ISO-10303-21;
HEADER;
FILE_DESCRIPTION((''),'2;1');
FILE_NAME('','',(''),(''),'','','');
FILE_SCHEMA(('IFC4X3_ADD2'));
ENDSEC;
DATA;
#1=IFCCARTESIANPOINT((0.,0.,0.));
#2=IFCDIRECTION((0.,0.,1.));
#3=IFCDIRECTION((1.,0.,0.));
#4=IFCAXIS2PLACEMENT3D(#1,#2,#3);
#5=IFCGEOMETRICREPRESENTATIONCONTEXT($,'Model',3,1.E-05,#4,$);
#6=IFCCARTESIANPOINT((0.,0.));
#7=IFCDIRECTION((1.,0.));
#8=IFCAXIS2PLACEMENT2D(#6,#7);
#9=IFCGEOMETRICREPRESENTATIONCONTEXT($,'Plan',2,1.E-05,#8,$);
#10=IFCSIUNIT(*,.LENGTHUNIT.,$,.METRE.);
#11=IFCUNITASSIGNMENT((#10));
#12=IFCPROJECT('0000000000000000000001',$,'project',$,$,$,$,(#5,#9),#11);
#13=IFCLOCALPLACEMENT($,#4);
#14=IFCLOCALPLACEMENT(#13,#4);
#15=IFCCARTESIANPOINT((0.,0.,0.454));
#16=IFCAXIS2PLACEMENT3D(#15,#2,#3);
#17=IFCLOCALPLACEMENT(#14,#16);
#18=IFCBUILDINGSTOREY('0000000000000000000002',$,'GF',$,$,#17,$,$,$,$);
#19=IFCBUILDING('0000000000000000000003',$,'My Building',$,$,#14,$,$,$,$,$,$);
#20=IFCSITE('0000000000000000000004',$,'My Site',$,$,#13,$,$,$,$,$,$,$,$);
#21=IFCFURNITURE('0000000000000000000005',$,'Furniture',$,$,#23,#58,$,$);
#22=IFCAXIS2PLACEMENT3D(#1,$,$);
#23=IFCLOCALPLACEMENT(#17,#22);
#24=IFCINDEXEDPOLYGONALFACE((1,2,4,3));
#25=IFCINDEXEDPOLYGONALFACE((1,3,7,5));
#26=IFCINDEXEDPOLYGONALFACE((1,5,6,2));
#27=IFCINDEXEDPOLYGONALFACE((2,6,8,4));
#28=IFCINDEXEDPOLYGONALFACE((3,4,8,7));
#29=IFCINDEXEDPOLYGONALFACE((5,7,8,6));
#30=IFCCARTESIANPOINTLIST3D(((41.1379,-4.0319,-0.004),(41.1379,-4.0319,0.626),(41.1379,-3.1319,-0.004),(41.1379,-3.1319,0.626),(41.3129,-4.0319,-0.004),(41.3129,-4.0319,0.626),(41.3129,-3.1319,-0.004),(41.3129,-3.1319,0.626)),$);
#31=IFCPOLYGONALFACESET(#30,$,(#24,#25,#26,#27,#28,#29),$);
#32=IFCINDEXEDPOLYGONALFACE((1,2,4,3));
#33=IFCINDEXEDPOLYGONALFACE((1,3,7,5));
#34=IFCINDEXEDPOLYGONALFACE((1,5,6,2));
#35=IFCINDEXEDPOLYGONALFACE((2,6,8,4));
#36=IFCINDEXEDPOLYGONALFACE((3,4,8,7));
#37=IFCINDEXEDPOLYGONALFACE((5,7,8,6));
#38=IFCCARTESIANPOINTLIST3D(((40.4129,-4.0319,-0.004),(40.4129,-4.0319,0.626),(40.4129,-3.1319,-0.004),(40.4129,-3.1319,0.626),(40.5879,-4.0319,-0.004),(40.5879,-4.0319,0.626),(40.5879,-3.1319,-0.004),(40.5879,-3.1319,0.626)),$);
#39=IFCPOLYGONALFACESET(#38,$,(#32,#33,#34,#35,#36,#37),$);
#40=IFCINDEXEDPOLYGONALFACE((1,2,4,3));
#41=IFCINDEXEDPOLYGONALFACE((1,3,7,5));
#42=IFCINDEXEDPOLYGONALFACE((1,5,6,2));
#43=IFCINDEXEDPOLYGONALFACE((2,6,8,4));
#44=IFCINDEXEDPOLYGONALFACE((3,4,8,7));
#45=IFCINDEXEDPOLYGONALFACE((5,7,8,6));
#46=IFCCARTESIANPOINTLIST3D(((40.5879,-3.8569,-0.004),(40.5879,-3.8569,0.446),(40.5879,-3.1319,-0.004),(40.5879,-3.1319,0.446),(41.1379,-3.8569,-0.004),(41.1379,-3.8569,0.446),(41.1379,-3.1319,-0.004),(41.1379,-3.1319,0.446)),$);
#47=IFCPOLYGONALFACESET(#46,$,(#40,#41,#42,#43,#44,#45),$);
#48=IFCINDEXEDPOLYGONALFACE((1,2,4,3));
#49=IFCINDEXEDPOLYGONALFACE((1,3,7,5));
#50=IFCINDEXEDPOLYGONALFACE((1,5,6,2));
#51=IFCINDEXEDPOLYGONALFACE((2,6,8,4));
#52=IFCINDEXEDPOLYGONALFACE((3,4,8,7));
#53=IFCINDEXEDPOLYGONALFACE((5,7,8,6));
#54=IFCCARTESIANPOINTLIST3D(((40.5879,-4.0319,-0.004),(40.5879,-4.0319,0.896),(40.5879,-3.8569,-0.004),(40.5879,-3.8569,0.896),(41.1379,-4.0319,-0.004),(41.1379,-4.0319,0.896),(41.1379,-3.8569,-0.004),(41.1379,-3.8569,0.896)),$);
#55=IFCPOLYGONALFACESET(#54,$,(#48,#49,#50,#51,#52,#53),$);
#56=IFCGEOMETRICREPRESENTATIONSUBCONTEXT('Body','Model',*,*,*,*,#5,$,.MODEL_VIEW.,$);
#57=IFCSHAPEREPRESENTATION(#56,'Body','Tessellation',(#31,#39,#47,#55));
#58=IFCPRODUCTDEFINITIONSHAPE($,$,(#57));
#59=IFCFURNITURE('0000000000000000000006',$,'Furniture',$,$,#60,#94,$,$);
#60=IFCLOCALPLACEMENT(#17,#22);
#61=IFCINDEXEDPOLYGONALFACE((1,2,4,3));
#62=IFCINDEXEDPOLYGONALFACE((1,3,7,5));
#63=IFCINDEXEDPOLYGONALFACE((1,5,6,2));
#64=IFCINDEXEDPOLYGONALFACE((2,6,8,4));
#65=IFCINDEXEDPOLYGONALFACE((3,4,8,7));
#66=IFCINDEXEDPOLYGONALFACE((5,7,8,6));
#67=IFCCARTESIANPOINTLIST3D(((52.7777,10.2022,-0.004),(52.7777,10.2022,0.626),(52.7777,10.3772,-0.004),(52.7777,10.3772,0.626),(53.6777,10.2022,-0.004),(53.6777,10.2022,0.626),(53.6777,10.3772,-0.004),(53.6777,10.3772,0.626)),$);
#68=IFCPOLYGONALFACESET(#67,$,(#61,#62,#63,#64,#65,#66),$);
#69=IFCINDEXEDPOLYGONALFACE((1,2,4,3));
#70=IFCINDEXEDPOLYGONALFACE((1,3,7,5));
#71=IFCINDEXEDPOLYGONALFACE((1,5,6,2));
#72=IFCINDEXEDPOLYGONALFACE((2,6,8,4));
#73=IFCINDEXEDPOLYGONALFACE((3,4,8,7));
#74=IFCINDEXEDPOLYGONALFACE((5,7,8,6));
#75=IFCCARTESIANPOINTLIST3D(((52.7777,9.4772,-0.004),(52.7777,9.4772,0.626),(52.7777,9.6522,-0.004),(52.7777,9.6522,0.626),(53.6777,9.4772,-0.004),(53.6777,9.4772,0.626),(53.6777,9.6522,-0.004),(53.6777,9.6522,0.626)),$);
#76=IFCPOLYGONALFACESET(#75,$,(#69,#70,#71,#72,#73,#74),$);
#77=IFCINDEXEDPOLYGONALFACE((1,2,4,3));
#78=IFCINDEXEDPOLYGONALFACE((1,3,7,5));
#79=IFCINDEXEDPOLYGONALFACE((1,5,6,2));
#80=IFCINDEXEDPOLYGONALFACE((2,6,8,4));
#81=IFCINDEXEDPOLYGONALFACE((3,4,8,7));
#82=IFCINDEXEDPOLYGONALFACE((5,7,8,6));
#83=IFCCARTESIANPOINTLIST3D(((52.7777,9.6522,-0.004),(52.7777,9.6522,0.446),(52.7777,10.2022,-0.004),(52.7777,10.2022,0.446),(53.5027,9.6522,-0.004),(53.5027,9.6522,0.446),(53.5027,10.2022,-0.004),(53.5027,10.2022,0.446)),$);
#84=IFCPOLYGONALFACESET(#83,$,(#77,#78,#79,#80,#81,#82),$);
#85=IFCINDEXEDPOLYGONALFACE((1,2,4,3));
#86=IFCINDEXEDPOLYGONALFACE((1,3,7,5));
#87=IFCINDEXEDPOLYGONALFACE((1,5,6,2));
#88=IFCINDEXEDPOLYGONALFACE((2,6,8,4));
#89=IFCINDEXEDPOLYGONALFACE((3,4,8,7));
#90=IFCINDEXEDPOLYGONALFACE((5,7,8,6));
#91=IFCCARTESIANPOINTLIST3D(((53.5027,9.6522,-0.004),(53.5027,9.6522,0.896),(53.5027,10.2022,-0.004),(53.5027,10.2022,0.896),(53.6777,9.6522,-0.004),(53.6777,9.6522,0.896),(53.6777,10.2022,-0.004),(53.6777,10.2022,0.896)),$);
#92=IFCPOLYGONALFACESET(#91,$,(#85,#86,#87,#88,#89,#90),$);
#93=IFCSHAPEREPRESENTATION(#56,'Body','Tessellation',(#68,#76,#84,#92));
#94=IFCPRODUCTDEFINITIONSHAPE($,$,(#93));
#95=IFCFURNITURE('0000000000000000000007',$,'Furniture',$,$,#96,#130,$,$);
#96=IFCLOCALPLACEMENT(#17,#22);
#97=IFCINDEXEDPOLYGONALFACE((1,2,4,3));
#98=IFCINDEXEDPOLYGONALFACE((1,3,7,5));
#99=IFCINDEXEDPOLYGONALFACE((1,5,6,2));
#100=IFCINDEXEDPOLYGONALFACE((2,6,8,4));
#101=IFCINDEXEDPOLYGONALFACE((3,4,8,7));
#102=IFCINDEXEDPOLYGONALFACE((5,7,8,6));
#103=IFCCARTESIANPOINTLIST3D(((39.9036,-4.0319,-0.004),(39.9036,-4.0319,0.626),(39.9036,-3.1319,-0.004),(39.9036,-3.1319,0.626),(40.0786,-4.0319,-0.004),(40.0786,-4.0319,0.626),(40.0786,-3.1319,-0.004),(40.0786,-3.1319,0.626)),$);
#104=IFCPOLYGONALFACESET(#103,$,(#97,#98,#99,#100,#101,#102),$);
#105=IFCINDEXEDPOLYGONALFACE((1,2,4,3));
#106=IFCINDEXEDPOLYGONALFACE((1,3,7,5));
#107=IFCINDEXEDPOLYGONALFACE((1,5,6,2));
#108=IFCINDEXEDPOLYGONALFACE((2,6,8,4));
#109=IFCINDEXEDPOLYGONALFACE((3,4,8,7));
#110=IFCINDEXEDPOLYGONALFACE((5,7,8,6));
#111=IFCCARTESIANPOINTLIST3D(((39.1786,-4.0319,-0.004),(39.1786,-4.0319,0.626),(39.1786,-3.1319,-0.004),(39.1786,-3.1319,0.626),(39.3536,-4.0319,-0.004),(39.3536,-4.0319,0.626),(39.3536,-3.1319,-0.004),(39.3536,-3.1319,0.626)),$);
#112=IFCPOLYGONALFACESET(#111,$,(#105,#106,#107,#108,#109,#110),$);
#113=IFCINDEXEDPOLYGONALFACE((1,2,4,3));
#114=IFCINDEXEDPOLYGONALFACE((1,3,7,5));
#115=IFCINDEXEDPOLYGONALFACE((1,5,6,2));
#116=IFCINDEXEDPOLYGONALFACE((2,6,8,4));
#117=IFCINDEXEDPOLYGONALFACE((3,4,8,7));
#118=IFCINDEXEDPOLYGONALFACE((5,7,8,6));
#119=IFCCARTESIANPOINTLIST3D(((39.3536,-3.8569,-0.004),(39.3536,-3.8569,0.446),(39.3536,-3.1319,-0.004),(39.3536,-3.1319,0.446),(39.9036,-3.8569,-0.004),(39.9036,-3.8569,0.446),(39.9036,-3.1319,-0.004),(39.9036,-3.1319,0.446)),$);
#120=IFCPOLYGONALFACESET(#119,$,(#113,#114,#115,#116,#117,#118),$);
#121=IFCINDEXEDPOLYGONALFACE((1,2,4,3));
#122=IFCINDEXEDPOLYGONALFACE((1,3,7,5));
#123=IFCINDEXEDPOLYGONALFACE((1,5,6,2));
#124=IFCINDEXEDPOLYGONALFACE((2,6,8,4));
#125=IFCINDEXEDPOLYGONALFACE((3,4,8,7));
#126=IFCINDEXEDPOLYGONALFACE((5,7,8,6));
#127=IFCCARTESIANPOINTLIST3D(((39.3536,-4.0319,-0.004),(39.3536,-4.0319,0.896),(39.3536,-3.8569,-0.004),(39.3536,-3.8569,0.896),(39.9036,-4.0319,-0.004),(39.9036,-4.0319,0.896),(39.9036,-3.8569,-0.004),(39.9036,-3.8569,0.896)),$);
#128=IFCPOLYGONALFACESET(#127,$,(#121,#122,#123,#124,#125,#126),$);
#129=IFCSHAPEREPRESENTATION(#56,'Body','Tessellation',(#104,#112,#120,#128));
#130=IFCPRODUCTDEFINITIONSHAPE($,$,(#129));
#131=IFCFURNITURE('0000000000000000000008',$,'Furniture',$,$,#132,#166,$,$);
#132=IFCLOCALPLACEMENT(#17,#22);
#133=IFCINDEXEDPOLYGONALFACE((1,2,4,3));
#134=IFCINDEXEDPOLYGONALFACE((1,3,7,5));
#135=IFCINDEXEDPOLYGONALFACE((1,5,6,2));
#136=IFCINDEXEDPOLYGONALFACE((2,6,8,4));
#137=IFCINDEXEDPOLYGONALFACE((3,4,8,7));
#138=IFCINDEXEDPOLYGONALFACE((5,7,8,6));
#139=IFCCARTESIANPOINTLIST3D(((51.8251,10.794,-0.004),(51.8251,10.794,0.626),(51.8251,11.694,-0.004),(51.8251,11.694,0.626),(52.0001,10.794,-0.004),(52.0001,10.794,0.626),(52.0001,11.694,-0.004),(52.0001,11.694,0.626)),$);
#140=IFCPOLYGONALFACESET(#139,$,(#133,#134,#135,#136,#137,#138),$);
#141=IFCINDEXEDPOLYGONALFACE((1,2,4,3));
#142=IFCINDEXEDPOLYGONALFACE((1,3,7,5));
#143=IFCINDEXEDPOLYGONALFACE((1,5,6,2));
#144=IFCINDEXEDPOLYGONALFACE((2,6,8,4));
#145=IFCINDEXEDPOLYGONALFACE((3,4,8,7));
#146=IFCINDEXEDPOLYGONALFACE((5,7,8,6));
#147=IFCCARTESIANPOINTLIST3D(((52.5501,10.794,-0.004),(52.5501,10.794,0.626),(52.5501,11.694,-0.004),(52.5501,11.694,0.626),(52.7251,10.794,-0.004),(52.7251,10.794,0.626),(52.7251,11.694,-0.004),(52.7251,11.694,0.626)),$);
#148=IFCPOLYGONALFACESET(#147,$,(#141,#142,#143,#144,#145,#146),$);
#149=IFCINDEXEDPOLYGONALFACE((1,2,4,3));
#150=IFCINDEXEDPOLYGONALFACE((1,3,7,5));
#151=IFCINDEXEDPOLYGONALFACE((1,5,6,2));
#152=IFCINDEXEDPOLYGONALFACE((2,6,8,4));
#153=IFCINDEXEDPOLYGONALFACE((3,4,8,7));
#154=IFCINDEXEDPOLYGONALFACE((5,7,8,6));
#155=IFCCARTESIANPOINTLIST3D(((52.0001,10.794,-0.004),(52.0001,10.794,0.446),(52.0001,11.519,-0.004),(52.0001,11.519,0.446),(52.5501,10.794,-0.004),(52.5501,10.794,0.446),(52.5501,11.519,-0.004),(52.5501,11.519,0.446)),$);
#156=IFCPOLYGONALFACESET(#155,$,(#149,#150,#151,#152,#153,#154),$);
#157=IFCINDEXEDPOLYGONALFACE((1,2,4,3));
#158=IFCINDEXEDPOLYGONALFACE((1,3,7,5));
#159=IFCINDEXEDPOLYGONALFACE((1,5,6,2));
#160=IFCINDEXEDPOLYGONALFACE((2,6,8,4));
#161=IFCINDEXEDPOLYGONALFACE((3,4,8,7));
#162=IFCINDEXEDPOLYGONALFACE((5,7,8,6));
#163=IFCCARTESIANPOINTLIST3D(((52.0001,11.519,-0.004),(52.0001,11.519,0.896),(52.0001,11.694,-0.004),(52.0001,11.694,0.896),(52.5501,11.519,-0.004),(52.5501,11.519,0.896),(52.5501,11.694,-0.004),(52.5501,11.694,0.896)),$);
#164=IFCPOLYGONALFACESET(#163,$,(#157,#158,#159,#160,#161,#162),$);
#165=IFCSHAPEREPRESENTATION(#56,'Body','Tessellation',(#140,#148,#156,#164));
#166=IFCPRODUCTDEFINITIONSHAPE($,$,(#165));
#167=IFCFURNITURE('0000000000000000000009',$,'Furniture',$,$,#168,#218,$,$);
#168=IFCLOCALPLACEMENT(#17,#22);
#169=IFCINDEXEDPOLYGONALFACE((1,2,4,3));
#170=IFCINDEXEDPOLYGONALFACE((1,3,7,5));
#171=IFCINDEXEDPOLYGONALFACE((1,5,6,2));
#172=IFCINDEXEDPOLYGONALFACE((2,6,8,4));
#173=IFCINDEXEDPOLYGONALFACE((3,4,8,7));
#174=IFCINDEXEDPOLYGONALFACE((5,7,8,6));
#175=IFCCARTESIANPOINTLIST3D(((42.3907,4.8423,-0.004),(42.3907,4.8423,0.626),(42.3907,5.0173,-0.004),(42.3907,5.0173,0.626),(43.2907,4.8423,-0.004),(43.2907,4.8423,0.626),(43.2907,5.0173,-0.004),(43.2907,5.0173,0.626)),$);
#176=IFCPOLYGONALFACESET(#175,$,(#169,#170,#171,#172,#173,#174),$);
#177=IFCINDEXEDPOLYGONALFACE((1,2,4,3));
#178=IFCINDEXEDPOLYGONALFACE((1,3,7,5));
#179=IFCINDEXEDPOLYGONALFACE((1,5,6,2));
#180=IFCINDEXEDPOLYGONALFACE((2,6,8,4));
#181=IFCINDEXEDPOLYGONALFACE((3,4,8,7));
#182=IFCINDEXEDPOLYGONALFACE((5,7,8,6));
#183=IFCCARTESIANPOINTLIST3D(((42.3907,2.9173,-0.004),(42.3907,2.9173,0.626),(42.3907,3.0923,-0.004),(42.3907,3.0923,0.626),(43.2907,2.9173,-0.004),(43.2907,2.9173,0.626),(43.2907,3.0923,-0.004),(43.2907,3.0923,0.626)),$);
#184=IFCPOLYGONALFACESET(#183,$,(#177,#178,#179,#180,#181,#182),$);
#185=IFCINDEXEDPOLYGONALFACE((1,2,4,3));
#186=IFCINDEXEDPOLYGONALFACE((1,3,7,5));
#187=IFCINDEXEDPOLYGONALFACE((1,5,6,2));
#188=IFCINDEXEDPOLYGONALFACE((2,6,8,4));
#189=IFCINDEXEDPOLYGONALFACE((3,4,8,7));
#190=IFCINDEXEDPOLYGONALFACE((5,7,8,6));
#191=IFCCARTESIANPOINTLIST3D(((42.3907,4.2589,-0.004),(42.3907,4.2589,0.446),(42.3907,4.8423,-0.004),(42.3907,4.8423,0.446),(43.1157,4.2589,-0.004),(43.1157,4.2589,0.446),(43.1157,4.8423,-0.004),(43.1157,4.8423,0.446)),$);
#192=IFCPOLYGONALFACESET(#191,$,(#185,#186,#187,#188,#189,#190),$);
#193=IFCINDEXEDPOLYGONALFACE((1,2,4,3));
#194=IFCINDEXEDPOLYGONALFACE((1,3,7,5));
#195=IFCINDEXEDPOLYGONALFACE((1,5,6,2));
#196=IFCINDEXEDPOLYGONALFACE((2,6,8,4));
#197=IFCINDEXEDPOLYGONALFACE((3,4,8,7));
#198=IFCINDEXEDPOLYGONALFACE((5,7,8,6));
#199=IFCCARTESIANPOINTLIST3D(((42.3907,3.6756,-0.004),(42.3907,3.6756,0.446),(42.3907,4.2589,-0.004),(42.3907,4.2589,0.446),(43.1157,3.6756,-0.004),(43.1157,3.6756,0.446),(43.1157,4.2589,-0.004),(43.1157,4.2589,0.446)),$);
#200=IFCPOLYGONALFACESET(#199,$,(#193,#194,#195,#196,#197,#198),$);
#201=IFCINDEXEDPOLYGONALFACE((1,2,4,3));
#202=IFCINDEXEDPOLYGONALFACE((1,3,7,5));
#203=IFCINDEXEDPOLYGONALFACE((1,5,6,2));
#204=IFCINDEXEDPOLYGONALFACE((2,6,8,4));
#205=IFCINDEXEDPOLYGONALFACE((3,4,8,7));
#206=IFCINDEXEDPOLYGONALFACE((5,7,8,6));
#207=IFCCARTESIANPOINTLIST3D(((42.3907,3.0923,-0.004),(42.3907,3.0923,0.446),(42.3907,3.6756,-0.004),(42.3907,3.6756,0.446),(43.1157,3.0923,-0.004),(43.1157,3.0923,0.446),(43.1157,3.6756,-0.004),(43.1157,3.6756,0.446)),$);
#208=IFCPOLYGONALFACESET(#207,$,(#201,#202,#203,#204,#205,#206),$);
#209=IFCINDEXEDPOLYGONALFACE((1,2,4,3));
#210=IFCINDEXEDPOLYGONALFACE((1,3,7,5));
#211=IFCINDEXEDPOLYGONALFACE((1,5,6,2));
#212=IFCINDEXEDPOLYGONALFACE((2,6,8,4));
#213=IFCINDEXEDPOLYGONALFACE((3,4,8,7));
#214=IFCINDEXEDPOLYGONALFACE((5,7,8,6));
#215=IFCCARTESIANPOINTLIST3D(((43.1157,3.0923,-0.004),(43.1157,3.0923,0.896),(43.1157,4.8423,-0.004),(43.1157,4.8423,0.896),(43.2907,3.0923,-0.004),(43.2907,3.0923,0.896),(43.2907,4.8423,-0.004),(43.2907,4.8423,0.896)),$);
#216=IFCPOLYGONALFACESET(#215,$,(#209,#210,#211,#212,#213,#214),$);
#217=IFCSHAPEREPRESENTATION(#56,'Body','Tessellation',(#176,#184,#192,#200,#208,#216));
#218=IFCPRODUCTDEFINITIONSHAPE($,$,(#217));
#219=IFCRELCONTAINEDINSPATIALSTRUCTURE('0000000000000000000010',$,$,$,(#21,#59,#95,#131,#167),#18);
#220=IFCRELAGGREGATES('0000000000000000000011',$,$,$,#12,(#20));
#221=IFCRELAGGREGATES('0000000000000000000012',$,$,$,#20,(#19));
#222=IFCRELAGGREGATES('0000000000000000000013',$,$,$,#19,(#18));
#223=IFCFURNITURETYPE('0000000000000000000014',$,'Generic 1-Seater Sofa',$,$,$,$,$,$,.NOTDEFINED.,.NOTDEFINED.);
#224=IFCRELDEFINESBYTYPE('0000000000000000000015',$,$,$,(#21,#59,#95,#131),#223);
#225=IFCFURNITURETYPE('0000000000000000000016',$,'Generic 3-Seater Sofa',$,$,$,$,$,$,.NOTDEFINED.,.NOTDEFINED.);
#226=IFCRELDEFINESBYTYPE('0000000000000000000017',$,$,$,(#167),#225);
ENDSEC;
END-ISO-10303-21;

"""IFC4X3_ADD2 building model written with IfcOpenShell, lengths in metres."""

from ifc_helpers import new_model, entity, si_unit, frame, origin_with_axes, origin_2d_with_axis, place, context, subcontext, project, spatial, line, indexed_curve, outline, extrude, shape, source, transform, mapped, type_object, type_shapes, element, save


model = new_model("IFC4X3_ADD2")

# Units and contexts
model_context = context("Model", 3, precision=1e-05, world=origin_with_axes())
plan_context = context("Plan", 2, precision=1e-05, world=origin_2d_with_axis())
body_context_1 = subcontext(model_context, "Body", "Model", "MODEL_VIEW")
body_context_2 = subcontext(plan_context, "Body", "Plan", "PLAN_VIEW")
ifc_project = project(units=[si_unit("LENGTHUNIT", "METRE")], contexts=[model_context, plan_context])

# Site, building, storey
site_placement = place(None, origin_with_axes())
site = spatial("IfcSite", under=ifc_project, at=site_placement, Name="My Site")
building_placement = place(site_placement, origin_with_axes())
building = spatial("IfcBuilding", under=site, at=building_placement, Name="My Building")
storey_placement = place(building_placement, frame((0.0, 0.0, 0.454), z_axis=(0.0, 0.0, 1.0), x_axis=(1.0, 0.0, 0.0)))
storey = spatial("IfcBuildingStorey", under=building, at=storey_placement, Name="GF")

# Furniture
furniture_type_1 = type_object("IfcFurnitureType", Name="Generic 1-Seater Sofa", AssemblyPlace="NOTDEFINED", PredefinedType="NOTDEFINED")
shared_shape_1 = source(origin_with_axes(), body_context_1, "Body", "SweptSolid", [
    extrude(outline(indexed_curve([(0.0, 0.0), (0.175, 0.0), (0.175, 0.9), (0.0, 0.9)], segments=[line(4, 1), line(1, 2), line(2, 3), line(3, 4)], self_intersect=False)), frame((-0.45, -0.9, 0.0), z_axis=(0.0, 0.0, 1.0), x_axis=(1.0, 0.0, 0.0)), (0.0, 0.0, 1.0), 0.63),
    extrude(outline(indexed_curve([(0.0, 0.0), (0.175, 0.0), (0.175, 0.9), (0.0, 0.9)], segments=[line(1, 2, 3, 4, 1)])), frame((0.275, -0.9, 0.0), z_axis=(0.0, 0.0, 1.0), x_axis=(1.0, 0.0, 0.0)), (0.0, 0.0, 1.0), 0.63),
    extrude(outline(indexed_curve([(0.175, 0.0), (0.725, 0.0), (0.725, 0.725), (0.175, 0.725)], segments=[line(1, 2, 3, 4, 1)])), frame((-0.45, -0.9, 0.0), z_axis=(0.0, 0.0, 1.0), x_axis=(1.0, 0.0, 0.0)), (0.0, 0.0, 1.0), 0.45),
    extrude(outline(indexed_curve([(0.175, 0.725), (0.725, 0.725), (0.725, 0.9), (0.175, 0.9)], segments=[line(1, 2, 3, 4, 1)])), frame((-0.45, -0.9, 0.0), z_axis=(0.0, 0.0, 1.0), x_axis=(1.0, 0.0, 0.0)), (0.0, 0.0, 1.0), 0.9),
])
shared_shape_2 = source(origin_with_axes(), body_context_2, "Body", "Annotation2D", [
    entity("IfcGeometricCurveSet", [entity("IfcIndexedPolyCurve", entity("IfcCartesianPointList2D", [[0.275, -0.175], [0.275, -0.9], [0.45, -0.9], [0.45, 0.0], [0.275, 0.0], [0.275, -0.9], [-0.275, -0.9], [-0.275, 0.0], [-0.275, -0.175], [0.275, -0.175], [0.275, 0.0], [-0.275, 0.0], [-0.45, 0.0], [-0.45, -0.9], [-0.275, -0.9], [-0.275, -0.175]]))]),
])
type_shapes(furniture_type_1, [shared_shape_1, shared_shape_2])
for number, where, z_axis, x_axis, name in (
    (1, (40.8629, -4.0319, -0.004), (0.0, 0.0, 1.0), (-1.0, 0.0, 0.0), "Furniture"),
    (2, (53.6777, 9.9272, -0.004), (0.0, 0.0, 1.0), (0.0, -1.0, 0.0), "Furniture"),
    (3, (39.6286, -4.0319, -0.004), (0.0, 0.0, 1.0), (-1.0, 0.0, 0.0), "Furniture"),
    (4, (52.2751, 11.694, -0.004), (0.0, 0.0, 1.0), (1.0, 0.0, 0.0), "Furniture"),
):
    element("IfcFurniture", number, at=place(storey_placement, frame(where, z_axis=z_axis, x_axis=x_axis)), inside=storey, type_object=furniture_type_1, Name=name, shapes=[
        shape(body_context_1, "Body", "MappedRepresentation", [mapped(shared_shape_1, transform((0.0, 0.0, 0.0), x_axis=(1.0, 0.0, 0.0), y_axis=(0.0, 1.0, 0.0), z_axis=(0.0, 0.0, 1.0), scale=1.0))]),
        shape(body_context_2, "Body", "MappedRepresentation", [mapped(shared_shape_2, transform((0.0, 0.0, 0.0), x_axis=(1.0, 0.0, 0.0), y_axis=(0.0, 1.0, 0.0), z_axis=(0.0, 0.0, 1.0), scale=1.0))]),
    ])
furniture_type_2 = type_object("IfcFurnitureType", Name="Generic 3-Seater Sofa", AssemblyPlace="NOTDEFINED", PredefinedType="NOTDEFINED")
shared_shape_3 = source(origin_with_axes(), body_context_1, "Body", "SweptSolid", [
    extrude(outline(indexed_curve([(0.0, 0.0), (0.175, 0.0), (0.175, 0.9), (0.0, 0.9)], segments=[line(4, 1), line(1, 2), line(2, 3), line(3, 4)], self_intersect=False)), frame((-1.05, -0.9, 0.0), z_axis=(0.0, 0.0, 1.0), x_axis=(1.0, 0.0, 0.0)), (0.0, 0.0, 1.0), 0.63),
    extrude(outline(indexed_curve([(0.0, 0.0), (0.175, 0.0), (0.175, 0.9), (0.0, 0.9)], segments=[line(1, 2, 3, 4, 1)])), frame((0.875, -0.9, 0.0), z_axis=(0.0, 0.0, 1.0), x_axis=(1.0, 0.0, 0.0)), (0.0, 0.0, 1.0), 0.63),
    extrude(outline(indexed_curve([(0.175, 0.0), (0.7583, 0.0), (0.7583, 0.725), (0.175, 0.725)], segments=[line(1, 2, 3, 4, 1)])), frame((-1.05, -0.9, 0.0), z_axis=(0.0, 0.0, 1.0), x_axis=(1.0, 0.0, 0.0)), (0.0, 0.0, 1.0), 0.45),
    extrude(outline(indexed_curve([(0.7583, 0.0), (1.3417, 0.0), (1.3417, 0.725), (0.7583, 0.725)], segments=[line(1, 2, 3, 4, 1)])), frame((-1.05, -0.9, 0.0), z_axis=(0.0, 0.0, 1.0), x_axis=(1.0, 0.0, 0.0)), (0.0, 0.0, 1.0), 0.45),
    extrude(outline(indexed_curve([(1.3417, 0.0), (1.925, 0.0), (1.925, 0.725), (1.3417, 0.725)], segments=[line(1, 2, 3, 4, 1)])), frame((-1.05, -0.9, 0.0), z_axis=(0.0, 0.0, 1.0), x_axis=(1.0, 0.0, 0.0)), (0.0, 0.0, 1.0), 0.45),
    extrude(outline(indexed_curve([(0.175, 0.725), (1.925, 0.725), (1.925, 0.9), (0.175, 0.9)], segments=[line(1, 2, 3, 4, 1)])), frame((-1.05, -0.9, 0.0), z_axis=(0.0, 0.0, 1.0), x_axis=(1.0, 0.0, 0.0)), (0.0, 0.0, 1.0), 0.9),
])
shared_shape_4 = source(origin_with_axes(), body_context_2, "Body", "Annotation2D", [
    entity("IfcGeometricCurveSet", [entity("IfcIndexedPolyCurve", entity("IfcCartesianPointList2D", [[0.2917, -0.175], [0.2917, -0.9], [0.875, -0.9], [0.875, -0.175], [-0.875, -0.175], [-0.875, 0.0], [0.875, 0.0], [1.05, 0.0], [1.05, -0.9], [0.875, -0.9], [0.875, 0.0], [0.875, -0.175], [0.2917, -0.175], [-0.2917, -0.175], [-0.2917, -0.9], [-0.875, -0.9], [-0.875, 0.0], [-1.05, 0.0], [-1.05, -0.9], [-0.875, -0.9], [-0.875, -0.175], [-0.2917, -0.175]])), entity("IfcIndexedPolyCurve", entity("IfcCartesianPointList2D", [[0.2917, -0.9], [-0.2917, -0.9]]))]),
])
type_shapes(furniture_type_2, [shared_shape_3, shared_shape_4])
furniture_1_placement = place(storey_placement, frame((43.2907, 3.9673, -0.004), z_axis=(0.0, 0.0, 1.0), x_axis=(0.0, -1.0, 0.0)))
element("IfcFurniture", 5, at=furniture_1_placement, inside=storey, type_object=furniture_type_2, Name="Furniture", shapes=[
    shape(body_context_1, "Body", "MappedRepresentation", [mapped(shared_shape_3, transform((0.0, 0.0, 0.0), x_axis=(1.0, 0.0, 0.0), y_axis=(0.0, 1.0, 0.0), z_axis=(0.0, 0.0, 1.0), scale=1.0))]),
    shape(body_context_2, "Body", "MappedRepresentation", [mapped(shared_shape_4, transform((0.0, 0.0, 0.0), x_axis=(1.0, 0.0, 0.0), y_axis=(0.0, 1.0, 0.0), z_axis=(0.0, 0.0, 1.0), scale=1.0))]),
])

save(model, "model.ifc")
